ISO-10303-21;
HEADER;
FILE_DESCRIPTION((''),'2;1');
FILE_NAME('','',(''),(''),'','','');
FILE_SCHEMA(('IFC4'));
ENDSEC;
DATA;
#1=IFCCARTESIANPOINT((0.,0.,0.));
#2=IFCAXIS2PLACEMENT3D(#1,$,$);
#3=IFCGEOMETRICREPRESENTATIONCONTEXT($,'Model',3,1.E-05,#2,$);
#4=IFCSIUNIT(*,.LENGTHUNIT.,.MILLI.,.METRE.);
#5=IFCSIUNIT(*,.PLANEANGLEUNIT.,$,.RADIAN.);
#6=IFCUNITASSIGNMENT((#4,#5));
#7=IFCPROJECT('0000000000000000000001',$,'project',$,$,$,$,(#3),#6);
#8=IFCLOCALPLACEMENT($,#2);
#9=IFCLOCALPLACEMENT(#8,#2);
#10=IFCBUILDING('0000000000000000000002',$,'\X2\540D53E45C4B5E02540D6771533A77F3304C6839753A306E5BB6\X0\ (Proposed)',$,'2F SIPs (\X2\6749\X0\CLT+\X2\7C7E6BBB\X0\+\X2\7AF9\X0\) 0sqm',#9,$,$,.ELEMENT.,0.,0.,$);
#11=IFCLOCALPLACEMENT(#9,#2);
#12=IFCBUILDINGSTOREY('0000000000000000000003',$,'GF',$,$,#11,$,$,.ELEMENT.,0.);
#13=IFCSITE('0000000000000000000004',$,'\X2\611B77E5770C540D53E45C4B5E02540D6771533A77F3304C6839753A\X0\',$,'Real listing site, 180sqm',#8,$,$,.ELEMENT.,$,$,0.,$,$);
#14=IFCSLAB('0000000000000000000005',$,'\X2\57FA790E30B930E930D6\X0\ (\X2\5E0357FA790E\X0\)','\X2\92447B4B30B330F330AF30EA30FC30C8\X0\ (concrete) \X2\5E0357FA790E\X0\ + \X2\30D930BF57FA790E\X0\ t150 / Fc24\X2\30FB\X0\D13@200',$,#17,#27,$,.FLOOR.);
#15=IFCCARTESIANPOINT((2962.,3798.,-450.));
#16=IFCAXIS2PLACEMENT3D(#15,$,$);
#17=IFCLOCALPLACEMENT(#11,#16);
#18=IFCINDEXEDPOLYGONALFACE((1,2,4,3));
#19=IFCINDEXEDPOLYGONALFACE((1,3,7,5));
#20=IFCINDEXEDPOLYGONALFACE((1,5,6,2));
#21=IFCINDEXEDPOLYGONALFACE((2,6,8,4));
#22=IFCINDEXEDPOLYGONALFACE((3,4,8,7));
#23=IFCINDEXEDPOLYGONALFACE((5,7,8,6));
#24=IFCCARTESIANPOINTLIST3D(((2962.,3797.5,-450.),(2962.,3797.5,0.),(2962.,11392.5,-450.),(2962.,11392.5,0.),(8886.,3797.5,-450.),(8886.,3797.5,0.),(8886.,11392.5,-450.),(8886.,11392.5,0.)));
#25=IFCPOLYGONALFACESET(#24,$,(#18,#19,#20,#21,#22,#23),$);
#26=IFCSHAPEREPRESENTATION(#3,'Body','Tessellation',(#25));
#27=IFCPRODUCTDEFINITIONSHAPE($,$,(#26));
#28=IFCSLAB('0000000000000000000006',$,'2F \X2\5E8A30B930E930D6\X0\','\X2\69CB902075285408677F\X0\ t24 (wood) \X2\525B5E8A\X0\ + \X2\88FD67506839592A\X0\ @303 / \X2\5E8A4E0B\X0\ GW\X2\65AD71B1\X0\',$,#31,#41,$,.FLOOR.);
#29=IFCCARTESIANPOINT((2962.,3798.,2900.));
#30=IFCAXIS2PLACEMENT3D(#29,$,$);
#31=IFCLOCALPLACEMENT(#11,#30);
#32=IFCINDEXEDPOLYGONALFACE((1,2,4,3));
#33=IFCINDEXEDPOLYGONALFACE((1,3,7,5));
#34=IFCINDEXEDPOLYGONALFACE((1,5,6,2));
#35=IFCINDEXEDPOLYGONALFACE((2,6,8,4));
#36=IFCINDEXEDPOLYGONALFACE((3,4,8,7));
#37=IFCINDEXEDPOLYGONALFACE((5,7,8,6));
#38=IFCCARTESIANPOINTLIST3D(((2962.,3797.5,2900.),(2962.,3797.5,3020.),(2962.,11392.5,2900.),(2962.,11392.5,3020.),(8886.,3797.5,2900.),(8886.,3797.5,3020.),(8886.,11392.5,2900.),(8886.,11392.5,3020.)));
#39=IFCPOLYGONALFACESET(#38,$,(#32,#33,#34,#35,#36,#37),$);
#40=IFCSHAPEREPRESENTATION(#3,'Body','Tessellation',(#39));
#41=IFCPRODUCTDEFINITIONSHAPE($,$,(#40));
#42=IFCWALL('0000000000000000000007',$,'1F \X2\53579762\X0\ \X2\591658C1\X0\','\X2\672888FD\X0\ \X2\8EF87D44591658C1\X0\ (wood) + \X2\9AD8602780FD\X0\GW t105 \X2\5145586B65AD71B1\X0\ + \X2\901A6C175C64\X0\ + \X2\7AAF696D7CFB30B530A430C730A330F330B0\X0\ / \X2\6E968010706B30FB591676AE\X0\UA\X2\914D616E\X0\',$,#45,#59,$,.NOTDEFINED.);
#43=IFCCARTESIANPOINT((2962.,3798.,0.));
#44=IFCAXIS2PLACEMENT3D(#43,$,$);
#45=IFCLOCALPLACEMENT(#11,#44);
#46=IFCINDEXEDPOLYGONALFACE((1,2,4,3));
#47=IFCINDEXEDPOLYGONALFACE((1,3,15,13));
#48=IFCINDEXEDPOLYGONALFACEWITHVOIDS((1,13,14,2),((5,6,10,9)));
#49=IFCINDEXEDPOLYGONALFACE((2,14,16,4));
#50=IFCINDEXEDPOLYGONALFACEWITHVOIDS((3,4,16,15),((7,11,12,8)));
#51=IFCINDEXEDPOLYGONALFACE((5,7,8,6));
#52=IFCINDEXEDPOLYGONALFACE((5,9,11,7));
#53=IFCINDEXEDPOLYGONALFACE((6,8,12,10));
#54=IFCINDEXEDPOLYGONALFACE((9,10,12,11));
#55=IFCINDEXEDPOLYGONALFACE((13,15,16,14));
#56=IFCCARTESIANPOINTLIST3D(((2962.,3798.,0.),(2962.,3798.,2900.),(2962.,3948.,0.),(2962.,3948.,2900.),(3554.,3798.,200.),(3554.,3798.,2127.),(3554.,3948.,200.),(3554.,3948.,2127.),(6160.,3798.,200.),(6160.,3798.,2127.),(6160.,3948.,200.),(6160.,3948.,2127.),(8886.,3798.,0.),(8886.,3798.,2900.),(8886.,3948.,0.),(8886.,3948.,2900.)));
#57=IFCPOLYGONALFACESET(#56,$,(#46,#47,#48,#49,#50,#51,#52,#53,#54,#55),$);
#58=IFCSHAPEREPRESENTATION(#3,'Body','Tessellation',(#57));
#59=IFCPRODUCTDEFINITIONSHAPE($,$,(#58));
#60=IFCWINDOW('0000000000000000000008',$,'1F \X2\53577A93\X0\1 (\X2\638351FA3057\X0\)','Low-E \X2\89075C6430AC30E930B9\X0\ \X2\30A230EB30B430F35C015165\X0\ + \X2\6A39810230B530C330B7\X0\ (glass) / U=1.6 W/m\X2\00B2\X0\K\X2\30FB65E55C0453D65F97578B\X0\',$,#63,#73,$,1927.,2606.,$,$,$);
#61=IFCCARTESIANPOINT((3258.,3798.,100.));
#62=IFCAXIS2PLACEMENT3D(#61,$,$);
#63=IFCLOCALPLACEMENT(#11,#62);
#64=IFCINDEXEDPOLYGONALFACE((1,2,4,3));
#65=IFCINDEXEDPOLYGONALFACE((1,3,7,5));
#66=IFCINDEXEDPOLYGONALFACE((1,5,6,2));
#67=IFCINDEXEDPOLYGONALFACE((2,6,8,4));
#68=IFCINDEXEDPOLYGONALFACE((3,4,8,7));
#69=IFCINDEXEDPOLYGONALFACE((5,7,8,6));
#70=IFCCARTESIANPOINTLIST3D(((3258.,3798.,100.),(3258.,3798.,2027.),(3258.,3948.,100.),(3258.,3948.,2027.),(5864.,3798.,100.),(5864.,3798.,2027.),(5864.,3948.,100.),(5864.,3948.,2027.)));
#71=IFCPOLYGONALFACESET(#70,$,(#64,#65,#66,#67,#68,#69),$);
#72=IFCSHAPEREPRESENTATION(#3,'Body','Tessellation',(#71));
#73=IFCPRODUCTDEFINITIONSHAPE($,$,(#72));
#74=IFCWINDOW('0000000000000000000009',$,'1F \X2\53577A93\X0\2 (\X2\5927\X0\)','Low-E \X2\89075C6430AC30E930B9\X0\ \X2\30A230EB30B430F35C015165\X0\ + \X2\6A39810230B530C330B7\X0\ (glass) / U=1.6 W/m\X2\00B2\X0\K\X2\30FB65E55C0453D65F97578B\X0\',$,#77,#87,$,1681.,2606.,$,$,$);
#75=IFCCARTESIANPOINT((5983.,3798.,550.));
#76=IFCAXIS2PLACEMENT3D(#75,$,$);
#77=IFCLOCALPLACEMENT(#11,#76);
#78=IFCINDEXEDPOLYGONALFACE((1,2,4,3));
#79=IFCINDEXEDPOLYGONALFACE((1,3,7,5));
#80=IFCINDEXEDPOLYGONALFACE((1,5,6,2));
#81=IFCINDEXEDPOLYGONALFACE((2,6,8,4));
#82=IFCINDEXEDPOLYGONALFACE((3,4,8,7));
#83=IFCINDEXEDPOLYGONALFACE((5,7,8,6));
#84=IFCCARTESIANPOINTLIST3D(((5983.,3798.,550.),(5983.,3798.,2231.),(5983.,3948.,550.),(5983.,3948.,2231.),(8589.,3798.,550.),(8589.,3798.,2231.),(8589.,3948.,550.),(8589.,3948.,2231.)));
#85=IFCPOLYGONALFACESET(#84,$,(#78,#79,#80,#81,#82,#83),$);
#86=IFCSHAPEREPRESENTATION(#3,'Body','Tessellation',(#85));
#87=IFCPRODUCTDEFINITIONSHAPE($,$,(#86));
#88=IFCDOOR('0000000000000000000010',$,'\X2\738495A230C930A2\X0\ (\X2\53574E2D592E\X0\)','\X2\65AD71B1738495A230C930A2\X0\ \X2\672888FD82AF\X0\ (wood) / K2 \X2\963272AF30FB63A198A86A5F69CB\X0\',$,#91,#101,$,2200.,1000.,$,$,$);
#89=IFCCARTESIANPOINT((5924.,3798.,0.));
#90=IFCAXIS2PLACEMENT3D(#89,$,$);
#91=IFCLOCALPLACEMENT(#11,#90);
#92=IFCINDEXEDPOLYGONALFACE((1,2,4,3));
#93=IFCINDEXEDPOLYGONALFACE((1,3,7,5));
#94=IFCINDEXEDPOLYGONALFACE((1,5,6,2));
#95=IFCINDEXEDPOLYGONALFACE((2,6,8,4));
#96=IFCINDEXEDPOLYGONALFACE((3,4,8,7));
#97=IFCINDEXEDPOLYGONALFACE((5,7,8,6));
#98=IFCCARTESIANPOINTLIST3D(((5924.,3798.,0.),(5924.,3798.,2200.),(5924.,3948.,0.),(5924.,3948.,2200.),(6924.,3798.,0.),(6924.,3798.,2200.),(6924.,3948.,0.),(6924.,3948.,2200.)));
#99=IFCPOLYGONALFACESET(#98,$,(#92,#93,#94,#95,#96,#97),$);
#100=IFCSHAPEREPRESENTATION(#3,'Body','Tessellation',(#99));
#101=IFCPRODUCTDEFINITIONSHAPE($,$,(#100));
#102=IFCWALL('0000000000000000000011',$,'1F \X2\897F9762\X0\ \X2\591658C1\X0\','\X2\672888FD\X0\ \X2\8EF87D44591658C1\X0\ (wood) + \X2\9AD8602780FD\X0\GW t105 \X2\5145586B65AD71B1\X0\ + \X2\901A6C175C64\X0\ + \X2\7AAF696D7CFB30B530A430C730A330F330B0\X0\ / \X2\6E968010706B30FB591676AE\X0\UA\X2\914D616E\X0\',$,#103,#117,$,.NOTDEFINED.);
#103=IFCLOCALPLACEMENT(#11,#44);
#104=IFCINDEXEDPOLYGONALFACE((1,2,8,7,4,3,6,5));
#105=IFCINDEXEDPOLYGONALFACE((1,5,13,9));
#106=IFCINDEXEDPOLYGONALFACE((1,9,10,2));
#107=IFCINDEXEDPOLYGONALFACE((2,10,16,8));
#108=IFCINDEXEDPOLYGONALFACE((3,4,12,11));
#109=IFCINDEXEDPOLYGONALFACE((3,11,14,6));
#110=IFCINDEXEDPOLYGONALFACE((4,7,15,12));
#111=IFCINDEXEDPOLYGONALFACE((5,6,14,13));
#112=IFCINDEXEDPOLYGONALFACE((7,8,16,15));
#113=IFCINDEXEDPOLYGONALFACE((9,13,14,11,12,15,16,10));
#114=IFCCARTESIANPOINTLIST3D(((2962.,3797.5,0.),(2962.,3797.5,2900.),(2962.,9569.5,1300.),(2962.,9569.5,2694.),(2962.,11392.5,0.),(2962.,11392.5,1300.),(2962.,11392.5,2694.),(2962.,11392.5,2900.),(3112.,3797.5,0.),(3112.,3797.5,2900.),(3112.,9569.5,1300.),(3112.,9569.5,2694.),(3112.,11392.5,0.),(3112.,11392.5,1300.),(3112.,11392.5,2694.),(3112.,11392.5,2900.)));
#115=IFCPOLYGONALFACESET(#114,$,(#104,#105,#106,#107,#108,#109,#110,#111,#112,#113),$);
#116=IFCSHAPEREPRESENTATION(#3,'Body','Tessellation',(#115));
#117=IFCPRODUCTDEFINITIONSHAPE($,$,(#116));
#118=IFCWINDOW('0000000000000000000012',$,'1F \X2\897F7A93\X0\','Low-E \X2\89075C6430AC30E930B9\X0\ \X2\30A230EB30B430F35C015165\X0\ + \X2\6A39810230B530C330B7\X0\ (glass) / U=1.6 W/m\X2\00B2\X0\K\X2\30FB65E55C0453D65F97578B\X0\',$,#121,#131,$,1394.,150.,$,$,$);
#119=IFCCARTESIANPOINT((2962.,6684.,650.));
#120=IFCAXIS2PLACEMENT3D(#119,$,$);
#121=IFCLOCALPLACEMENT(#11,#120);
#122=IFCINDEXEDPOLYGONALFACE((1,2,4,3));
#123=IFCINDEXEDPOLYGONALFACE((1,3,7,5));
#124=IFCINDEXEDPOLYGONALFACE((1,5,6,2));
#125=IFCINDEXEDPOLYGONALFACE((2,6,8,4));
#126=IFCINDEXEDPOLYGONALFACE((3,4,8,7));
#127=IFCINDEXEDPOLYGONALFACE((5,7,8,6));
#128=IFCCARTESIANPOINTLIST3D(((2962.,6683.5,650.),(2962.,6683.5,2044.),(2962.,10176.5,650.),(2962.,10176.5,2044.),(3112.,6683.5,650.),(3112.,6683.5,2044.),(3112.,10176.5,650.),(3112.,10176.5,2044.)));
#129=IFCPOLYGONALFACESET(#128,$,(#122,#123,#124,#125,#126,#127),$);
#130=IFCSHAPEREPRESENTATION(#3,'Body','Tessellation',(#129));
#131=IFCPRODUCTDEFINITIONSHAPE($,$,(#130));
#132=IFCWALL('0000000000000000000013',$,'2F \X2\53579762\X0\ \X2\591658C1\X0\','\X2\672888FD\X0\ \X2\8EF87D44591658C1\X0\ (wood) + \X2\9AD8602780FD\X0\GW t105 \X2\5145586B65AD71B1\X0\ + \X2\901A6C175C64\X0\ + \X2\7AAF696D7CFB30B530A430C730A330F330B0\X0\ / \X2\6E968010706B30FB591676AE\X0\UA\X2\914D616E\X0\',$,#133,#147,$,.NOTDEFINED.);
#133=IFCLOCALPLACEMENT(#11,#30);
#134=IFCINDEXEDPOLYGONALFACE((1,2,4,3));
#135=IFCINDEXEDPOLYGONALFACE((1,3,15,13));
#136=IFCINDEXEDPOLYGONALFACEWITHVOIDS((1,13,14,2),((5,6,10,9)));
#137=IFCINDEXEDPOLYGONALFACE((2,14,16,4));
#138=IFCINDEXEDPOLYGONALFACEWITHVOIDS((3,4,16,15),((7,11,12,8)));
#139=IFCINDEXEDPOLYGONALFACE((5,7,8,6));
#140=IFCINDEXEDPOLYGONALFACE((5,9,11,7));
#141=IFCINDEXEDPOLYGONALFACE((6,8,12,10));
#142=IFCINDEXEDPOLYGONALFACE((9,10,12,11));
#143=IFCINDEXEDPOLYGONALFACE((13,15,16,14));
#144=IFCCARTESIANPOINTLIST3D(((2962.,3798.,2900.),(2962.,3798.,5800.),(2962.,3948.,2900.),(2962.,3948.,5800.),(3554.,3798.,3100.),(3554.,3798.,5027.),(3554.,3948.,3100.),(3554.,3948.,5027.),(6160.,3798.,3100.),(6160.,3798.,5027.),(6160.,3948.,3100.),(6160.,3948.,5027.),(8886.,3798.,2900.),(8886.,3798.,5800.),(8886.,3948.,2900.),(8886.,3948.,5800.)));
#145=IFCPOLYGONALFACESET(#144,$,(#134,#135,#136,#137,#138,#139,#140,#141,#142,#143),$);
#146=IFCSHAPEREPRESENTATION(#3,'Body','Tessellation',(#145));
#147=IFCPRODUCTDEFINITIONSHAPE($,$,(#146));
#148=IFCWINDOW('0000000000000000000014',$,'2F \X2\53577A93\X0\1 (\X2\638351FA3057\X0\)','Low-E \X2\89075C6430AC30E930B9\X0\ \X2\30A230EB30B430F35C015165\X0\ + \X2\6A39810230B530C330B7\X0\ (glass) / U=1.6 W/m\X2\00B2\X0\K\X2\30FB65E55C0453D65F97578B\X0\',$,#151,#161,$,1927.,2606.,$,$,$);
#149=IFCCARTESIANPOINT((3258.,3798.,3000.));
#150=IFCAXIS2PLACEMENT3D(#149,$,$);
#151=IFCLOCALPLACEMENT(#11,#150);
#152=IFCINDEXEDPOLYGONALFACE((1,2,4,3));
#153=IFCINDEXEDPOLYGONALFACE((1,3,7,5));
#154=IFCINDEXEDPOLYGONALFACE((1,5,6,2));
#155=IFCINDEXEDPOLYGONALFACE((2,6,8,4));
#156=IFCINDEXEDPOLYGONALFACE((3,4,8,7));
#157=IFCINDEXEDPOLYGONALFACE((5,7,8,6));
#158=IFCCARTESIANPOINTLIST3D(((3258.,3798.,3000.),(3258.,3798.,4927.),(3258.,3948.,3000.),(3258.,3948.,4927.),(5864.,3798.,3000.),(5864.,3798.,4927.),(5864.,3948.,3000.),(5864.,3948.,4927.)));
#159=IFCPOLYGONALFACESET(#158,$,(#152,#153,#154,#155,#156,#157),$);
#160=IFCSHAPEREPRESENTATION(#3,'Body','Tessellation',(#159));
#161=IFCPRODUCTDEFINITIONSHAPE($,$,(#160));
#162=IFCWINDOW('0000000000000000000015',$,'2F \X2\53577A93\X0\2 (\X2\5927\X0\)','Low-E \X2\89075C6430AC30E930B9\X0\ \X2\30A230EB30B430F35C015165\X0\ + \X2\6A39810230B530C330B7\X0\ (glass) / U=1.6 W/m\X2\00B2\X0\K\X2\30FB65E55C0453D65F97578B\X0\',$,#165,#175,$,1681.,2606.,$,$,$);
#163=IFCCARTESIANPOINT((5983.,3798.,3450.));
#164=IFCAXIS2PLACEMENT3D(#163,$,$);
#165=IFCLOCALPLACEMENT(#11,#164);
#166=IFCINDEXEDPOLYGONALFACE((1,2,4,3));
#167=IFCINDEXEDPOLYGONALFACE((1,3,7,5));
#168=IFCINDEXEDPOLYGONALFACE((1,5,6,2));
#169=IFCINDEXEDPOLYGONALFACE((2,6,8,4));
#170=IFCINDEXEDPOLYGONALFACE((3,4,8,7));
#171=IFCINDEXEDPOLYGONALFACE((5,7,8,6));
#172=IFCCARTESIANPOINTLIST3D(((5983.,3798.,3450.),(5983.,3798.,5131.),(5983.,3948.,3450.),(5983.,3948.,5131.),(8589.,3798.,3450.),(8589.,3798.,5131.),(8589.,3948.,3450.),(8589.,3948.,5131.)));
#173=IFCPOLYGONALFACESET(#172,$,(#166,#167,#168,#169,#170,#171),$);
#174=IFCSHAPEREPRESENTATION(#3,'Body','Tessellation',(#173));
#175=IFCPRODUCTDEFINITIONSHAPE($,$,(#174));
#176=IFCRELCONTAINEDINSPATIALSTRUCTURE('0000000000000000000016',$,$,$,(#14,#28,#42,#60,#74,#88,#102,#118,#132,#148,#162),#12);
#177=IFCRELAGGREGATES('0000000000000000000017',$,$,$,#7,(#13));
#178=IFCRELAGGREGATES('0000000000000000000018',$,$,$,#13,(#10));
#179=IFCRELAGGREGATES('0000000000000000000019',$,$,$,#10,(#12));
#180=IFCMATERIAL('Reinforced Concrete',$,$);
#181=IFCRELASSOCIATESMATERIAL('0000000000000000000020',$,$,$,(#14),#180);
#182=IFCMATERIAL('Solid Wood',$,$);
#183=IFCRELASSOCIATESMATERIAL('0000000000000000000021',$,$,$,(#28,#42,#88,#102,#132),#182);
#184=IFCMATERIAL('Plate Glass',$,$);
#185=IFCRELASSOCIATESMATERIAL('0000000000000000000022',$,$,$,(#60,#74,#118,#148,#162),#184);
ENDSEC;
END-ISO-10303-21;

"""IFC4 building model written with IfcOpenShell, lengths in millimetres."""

from ifc_helpers import new_model, si_unit, frame, frame_2d, origin, place, context, project, spatial, rectangle, extrude, material, element, fill, save


model = new_model("IFC4")

# Units and contexts
model_context = context("Model", 3, precision=1e-05, world=origin())
ifc_project = project(units=[si_unit("LENGTHUNIT", "METRE", prefix="MILLI"), si_unit("PLANEANGLEUNIT", "RADIAN")], contexts=[model_context])

# Site, building, storey
site_placement = place(None, origin())
site = spatial("IfcSite", under=ifc_project, at=site_placement, Name="愛知県名古屋市名東区石が根町", ObjectType="Real listing site, 180sqm", CompositionType="ELEMENT", RefElevation=0.0)
building_placement = place(site_placement, origin())
building = spatial("IfcBuilding", under=site, at=building_placement, Name="名古屋市名東区石が根町の家 (Proposed)", ObjectType="2F SIPs (杉CLT+籾殻+竹) 0sqm", CompositionType="ELEMENT", ElevationOfRefHeight=0.0, ElevationOfTerrain=0.0)
storey_placement = place(building_placement, origin())
storey = spatial("IfcBuildingStorey", under=building, at=storey_placement, Name="GF", CompositionType="ELEMENT", Elevation=0.0)

# Slabs
ifc_material_1 = material(Name="Reinforced Concrete")
slab_1_placement = place(storey_placement, frame((2962.0, 3798.0, -450.0)))
element("IfcSlab", 1, at=slab_1_placement, inside=storey, material=ifc_material_1, Name="基礎スラブ (布基礎)", Description="鉄筋コンクリート (concrete) 布基礎 + ベタ基礎 t150 / Fc24・D13@200", PredefinedType="FLOOR", context=model_context, shape_type="SweptSolid", body=[
    extrude(rectangle(XDim=5924.0, YDim=7595.0, at=frame_2d((2962.0, 3797.0))), frame((2962.0, 3798.0, -450.0)), (0.0, 0.0, 1.0), 450.0),
])
ifc_material_2 = material(Name="Solid Wood")
slab_2_placement = place(storey_placement, frame((2962.0, 3798.0, 2900.0)))
element("IfcSlab", 2, at=slab_2_placement, inside=storey, material=ifc_material_2, Name="2F 床スラブ", Description="構造用合板 t24 (wood) 剛床 + 製材根太 @303 / 床下 GW断熱", PredefinedType="FLOOR", context=model_context, shape_type="SweptSolid", body=[
    extrude(rectangle(XDim=5924.0, YDim=7595.0, at=frame_2d((2962.0, 3797.0))), frame((2962.0, 3798.0, 2900.0)), (0.0, 0.0, 1.0), 120.0),
])

# Wall, openings, windows, door
wall_1_placement = place(storey_placement, frame((2962.0, 3798.0, 0.0)))
wall_1 = element("IfcWall", 3, at=wall_1_placement, inside=storey, material=ifc_material_2, Name="1F 南面 外壁", Description="木製 軸組外壁 (wood) + 高性能GW t105 充填断熱 + 通気層 + 窯業系サイディング / 準耐火・外皮UA配慮", PredefinedType="NOTDEFINED", context=model_context, shape_type="SweptSolid", body=[
    extrude(rectangle(XDim=5924.0, YDim=150.0, at=frame_2d((2962.0, 75.0))), frame((2962.0, 3798.0, 0.0)), (0.0, 0.0, 1.0), 2900.0),
])
opening_1_placement = place(storey_placement, frame((3258.0, 3798.0, 100.0)))
opening_1 = element("IfcOpeningElement", 4, at=opening_1_placement, cuts=wall_1, PredefinedType="NOTDEFINED", context=model_context, shape_type="SweptSolid", body=[
    extrude(rectangle(XDim=2606.0, YDim=150.0, at=frame_2d((1303.0, 75.0))), frame((3258.0, 3798.0, 100.0)), (0.0, 0.0, 1.0), 1927.0),
])
opening_2_placement = place(storey_placement, frame((5983.0, 3798.0, 550.0)))
opening_2 = element("IfcOpeningElement", 5, at=opening_2_placement, cuts=wall_1, PredefinedType="NOTDEFINED", context=model_context, shape_type="SweptSolid", body=[
    extrude(rectangle(XDim=2606.0, YDim=150.0, at=frame_2d((1303.0, 75.0))), frame((5983.0, 3798.0, 550.0)), (0.0, 0.0, 1.0), 1681.0),
])
opening_3_placement = place(storey_placement, frame((5924.0, 3798.0, 0.0)))
opening_3 = element("IfcOpeningElement", 6, at=opening_3_placement, cuts=wall_1, PredefinedType="NOTDEFINED", context=model_context, shape_type="SweptSolid", body=[
    extrude(rectangle(XDim=1000.0, YDim=150.0, at=frame_2d((500.0, 75.0))), frame((5924.0, 3798.0, 0.0)), (0.0, 0.0, 1.0), 2200.0),
])
ifc_material_3 = material(Name="Plate Glass")
window_1_placement = place(storey_placement, frame((3258.0, 3798.0, 100.0)))
window_1 = element("IfcWindow", 7, at=window_1_placement, inside=storey, material=ifc_material_3, Name="1F 南窓1 (掃出し)", Description="Low-E 複層ガラス アルゴン封入 + 樹脂サッシ (glass) / U=1.6 W/m²K・日射取得型", OverallHeight=1927.0, OverallWidth=2606.0, context=model_context, shape_type="SweptSolid", body=[
    extrude(rectangle(XDim=2606.0, YDim=150.0, at=frame_2d((1303.0, 75.0))), frame((3258.0, 3798.0, 100.0)), (0.0, 0.0, 1.0), 1927.0),
])
fill(opening_1, window_1)
window_2_placement = place(storey_placement, frame((5983.0, 3798.0, 550.0)))
window_2 = element("IfcWindow", 8, at=window_2_placement, inside=storey, material=ifc_material_3, Name="1F 南窓2 (大)", Description="Low-E 複層ガラス アルゴン封入 + 樹脂サッシ (glass) / U=1.6 W/m²K・日射取得型", OverallHeight=1681.0, OverallWidth=2606.0, context=model_context, shape_type="SweptSolid", body=[
    extrude(rectangle(XDim=2606.0, YDim=150.0, at=frame_2d((1303.0, 75.0))), frame((5983.0, 3798.0, 550.0)), (0.0, 0.0, 1.0), 1681.0),
])
fill(opening_2, window_2)
door_placement = place(storey_placement, frame((5924.0, 3798.0, 0.0)))
door = element("IfcDoor", 9, at=door_placement, inside=storey, material=ifc_material_2, Name="玄関ドア (南中央)", Description="断熱玄関ドア 木製芯 (wood) / K2 防犯・採風機構", OverallHeight=2200.0, OverallWidth=1000.0, context=model_context, shape_type="SweptSolid", body=[
    extrude(rectangle(XDim=1000.0, YDim=150.0, at=frame_2d((500.0, 75.0))), frame((5924.0, 3798.0, 0.0)), (0.0, 0.0, 1.0), 2200.0),
])
fill(opening_3, door)

# Wall, opening, window
wall_2_placement = place(storey_placement, frame((2962.0, 3798.0, 0.0)))
wall_2 = element("IfcWall", 10, at=wall_2_placement, inside=storey, material=ifc_material_2, Name="1F 西面 外壁", Description="木製 軸組外壁 (wood) + 高性能GW t105 充填断熱 + 通気層 + 窯業系サイディング / 準耐火・外皮UA配慮", PredefinedType="NOTDEFINED", context=model_context, shape_type="SweptSolid", body=[
    extrude(rectangle(XDim=150.0, YDim=7595.0, at=frame_2d((75.0, 3797.0))), frame((2962.0, 3798.0, 0.0)), (0.0, 0.0, 1.0), 2900.0),
])
opening_4_placement = place(storey_placement, frame((2962.0, 6684.0, 650.0)))
opening_4 = element("IfcOpeningElement", 11, at=opening_4_placement, cuts=wall_2, PredefinedType="NOTDEFINED", context=model_context, shape_type="SweptSolid", body=[
    extrude(rectangle(XDim=150.0, YDim=3493.0, at=frame_2d((75.0, 1746.0))), frame((2962.0, 6684.0, 650.0)), (0.0, 0.0, 1.0), 1394.0),
])
window_3_placement = place(storey_placement, frame((2962.0, 6684.0, 650.0)))
window_3 = element("IfcWindow", 12, at=window_3_placement, inside=storey, material=ifc_material_3, Name="1F 西窓", Description="Low-E 複層ガラス アルゴン封入 + 樹脂サッシ (glass) / U=1.6 W/m²K・日射取得型", OverallHeight=1394.0, OverallWidth=150.0, context=model_context, shape_type="SweptSolid", body=[
    extrude(rectangle(XDim=150.0, YDim=3493.0, at=frame_2d((75.0, 1746.0))), frame((2962.0, 6684.0, 650.0)), (0.0, 0.0, 1.0), 1394.0),
])
fill(opening_4, window_3)

# Wall, openings, windows
wall_3_placement = place(storey_placement, frame((2962.0, 3798.0, 2900.0)))
wall_3 = element("IfcWall", 13, at=wall_3_placement, inside=storey, material=ifc_material_2, Name="2F 南面 外壁", Description="木製 軸組外壁 (wood) + 高性能GW t105 充填断熱 + 通気層 + 窯業系サイディング / 準耐火・外皮UA配慮", PredefinedType="NOTDEFINED", context=model_context, shape_type="SweptSolid", body=[
    extrude(rectangle(XDim=5924.0, YDim=150.0, at=frame_2d((2962.0, 75.0))), frame((2962.0, 3798.0, 2900.0)), (0.0, 0.0, 1.0), 2900.0),
])
opening_5_placement = place(storey_placement, frame((3258.0, 3798.0, 3000.0)))
opening_5 = element("IfcOpeningElement", 14, at=opening_5_placement, cuts=wall_3, PredefinedType="NOTDEFINED", context=model_context, shape_type="SweptSolid", body=[
    extrude(rectangle(XDim=2606.0, YDim=150.0, at=frame_2d((1303.0, 75.0))), frame((3258.0, 3798.0, 3000.0)), (0.0, 0.0, 1.0), 1927.0),
])
opening_6_placement = place(storey_placement, frame((5983.0, 3798.0, 3450.0)))
opening_6 = element("IfcOpeningElement", 15, at=opening_6_placement, cuts=wall_3, PredefinedType="NOTDEFINED", context=model_context, shape_type="SweptSolid", body=[
    extrude(rectangle(XDim=2606.0, YDim=150.0, at=frame_2d((1303.0, 75.0))), frame((5983.0, 3798.0, 3450.0)), (0.0, 0.0, 1.0), 1681.0),
])
window_4_placement = place(storey_placement, frame((3258.0, 3798.0, 3000.0)))
window_4 = element("IfcWindow", 16, at=window_4_placement, inside=storey, material=ifc_material_3, Name="2F 南窓1 (掃出し)", Description="Low-E 複層ガラス アルゴン封入 + 樹脂サッシ (glass) / U=1.6 W/m²K・日射取得型", OverallHeight=1927.0, OverallWidth=2606.0, context=model_context, shape_type="SweptSolid", body=[
    extrude(rectangle(XDim=2606.0, YDim=150.0, at=frame_2d((1303.0, 75.0))), frame((3258.0, 3798.0, 3000.0)), (0.0, 0.0, 1.0), 1927.0),
])
fill(opening_5, window_4)
window_5_placement = place(storey_placement, frame((5983.0, 3798.0, 3450.0)))
window_5 = element("IfcWindow", 17, at=window_5_placement, inside=storey, material=ifc_material_3, Name="2F 南窓2 (大)", Description="Low-E 複層ガラス アルゴン封入 + 樹脂サッシ (glass) / U=1.6 W/m²K・日射取得型", OverallHeight=1681.0, OverallWidth=2606.0, context=model_context, shape_type="SweptSolid", body=[
    extrude(rectangle(XDim=2606.0, YDim=150.0, at=frame_2d((1303.0, 75.0))), frame((5983.0, 3798.0, 3450.0)), (0.0, 0.0, 1.0), 1681.0),
])
fill(opening_6, window_5)

save(model, "model.ifc")
